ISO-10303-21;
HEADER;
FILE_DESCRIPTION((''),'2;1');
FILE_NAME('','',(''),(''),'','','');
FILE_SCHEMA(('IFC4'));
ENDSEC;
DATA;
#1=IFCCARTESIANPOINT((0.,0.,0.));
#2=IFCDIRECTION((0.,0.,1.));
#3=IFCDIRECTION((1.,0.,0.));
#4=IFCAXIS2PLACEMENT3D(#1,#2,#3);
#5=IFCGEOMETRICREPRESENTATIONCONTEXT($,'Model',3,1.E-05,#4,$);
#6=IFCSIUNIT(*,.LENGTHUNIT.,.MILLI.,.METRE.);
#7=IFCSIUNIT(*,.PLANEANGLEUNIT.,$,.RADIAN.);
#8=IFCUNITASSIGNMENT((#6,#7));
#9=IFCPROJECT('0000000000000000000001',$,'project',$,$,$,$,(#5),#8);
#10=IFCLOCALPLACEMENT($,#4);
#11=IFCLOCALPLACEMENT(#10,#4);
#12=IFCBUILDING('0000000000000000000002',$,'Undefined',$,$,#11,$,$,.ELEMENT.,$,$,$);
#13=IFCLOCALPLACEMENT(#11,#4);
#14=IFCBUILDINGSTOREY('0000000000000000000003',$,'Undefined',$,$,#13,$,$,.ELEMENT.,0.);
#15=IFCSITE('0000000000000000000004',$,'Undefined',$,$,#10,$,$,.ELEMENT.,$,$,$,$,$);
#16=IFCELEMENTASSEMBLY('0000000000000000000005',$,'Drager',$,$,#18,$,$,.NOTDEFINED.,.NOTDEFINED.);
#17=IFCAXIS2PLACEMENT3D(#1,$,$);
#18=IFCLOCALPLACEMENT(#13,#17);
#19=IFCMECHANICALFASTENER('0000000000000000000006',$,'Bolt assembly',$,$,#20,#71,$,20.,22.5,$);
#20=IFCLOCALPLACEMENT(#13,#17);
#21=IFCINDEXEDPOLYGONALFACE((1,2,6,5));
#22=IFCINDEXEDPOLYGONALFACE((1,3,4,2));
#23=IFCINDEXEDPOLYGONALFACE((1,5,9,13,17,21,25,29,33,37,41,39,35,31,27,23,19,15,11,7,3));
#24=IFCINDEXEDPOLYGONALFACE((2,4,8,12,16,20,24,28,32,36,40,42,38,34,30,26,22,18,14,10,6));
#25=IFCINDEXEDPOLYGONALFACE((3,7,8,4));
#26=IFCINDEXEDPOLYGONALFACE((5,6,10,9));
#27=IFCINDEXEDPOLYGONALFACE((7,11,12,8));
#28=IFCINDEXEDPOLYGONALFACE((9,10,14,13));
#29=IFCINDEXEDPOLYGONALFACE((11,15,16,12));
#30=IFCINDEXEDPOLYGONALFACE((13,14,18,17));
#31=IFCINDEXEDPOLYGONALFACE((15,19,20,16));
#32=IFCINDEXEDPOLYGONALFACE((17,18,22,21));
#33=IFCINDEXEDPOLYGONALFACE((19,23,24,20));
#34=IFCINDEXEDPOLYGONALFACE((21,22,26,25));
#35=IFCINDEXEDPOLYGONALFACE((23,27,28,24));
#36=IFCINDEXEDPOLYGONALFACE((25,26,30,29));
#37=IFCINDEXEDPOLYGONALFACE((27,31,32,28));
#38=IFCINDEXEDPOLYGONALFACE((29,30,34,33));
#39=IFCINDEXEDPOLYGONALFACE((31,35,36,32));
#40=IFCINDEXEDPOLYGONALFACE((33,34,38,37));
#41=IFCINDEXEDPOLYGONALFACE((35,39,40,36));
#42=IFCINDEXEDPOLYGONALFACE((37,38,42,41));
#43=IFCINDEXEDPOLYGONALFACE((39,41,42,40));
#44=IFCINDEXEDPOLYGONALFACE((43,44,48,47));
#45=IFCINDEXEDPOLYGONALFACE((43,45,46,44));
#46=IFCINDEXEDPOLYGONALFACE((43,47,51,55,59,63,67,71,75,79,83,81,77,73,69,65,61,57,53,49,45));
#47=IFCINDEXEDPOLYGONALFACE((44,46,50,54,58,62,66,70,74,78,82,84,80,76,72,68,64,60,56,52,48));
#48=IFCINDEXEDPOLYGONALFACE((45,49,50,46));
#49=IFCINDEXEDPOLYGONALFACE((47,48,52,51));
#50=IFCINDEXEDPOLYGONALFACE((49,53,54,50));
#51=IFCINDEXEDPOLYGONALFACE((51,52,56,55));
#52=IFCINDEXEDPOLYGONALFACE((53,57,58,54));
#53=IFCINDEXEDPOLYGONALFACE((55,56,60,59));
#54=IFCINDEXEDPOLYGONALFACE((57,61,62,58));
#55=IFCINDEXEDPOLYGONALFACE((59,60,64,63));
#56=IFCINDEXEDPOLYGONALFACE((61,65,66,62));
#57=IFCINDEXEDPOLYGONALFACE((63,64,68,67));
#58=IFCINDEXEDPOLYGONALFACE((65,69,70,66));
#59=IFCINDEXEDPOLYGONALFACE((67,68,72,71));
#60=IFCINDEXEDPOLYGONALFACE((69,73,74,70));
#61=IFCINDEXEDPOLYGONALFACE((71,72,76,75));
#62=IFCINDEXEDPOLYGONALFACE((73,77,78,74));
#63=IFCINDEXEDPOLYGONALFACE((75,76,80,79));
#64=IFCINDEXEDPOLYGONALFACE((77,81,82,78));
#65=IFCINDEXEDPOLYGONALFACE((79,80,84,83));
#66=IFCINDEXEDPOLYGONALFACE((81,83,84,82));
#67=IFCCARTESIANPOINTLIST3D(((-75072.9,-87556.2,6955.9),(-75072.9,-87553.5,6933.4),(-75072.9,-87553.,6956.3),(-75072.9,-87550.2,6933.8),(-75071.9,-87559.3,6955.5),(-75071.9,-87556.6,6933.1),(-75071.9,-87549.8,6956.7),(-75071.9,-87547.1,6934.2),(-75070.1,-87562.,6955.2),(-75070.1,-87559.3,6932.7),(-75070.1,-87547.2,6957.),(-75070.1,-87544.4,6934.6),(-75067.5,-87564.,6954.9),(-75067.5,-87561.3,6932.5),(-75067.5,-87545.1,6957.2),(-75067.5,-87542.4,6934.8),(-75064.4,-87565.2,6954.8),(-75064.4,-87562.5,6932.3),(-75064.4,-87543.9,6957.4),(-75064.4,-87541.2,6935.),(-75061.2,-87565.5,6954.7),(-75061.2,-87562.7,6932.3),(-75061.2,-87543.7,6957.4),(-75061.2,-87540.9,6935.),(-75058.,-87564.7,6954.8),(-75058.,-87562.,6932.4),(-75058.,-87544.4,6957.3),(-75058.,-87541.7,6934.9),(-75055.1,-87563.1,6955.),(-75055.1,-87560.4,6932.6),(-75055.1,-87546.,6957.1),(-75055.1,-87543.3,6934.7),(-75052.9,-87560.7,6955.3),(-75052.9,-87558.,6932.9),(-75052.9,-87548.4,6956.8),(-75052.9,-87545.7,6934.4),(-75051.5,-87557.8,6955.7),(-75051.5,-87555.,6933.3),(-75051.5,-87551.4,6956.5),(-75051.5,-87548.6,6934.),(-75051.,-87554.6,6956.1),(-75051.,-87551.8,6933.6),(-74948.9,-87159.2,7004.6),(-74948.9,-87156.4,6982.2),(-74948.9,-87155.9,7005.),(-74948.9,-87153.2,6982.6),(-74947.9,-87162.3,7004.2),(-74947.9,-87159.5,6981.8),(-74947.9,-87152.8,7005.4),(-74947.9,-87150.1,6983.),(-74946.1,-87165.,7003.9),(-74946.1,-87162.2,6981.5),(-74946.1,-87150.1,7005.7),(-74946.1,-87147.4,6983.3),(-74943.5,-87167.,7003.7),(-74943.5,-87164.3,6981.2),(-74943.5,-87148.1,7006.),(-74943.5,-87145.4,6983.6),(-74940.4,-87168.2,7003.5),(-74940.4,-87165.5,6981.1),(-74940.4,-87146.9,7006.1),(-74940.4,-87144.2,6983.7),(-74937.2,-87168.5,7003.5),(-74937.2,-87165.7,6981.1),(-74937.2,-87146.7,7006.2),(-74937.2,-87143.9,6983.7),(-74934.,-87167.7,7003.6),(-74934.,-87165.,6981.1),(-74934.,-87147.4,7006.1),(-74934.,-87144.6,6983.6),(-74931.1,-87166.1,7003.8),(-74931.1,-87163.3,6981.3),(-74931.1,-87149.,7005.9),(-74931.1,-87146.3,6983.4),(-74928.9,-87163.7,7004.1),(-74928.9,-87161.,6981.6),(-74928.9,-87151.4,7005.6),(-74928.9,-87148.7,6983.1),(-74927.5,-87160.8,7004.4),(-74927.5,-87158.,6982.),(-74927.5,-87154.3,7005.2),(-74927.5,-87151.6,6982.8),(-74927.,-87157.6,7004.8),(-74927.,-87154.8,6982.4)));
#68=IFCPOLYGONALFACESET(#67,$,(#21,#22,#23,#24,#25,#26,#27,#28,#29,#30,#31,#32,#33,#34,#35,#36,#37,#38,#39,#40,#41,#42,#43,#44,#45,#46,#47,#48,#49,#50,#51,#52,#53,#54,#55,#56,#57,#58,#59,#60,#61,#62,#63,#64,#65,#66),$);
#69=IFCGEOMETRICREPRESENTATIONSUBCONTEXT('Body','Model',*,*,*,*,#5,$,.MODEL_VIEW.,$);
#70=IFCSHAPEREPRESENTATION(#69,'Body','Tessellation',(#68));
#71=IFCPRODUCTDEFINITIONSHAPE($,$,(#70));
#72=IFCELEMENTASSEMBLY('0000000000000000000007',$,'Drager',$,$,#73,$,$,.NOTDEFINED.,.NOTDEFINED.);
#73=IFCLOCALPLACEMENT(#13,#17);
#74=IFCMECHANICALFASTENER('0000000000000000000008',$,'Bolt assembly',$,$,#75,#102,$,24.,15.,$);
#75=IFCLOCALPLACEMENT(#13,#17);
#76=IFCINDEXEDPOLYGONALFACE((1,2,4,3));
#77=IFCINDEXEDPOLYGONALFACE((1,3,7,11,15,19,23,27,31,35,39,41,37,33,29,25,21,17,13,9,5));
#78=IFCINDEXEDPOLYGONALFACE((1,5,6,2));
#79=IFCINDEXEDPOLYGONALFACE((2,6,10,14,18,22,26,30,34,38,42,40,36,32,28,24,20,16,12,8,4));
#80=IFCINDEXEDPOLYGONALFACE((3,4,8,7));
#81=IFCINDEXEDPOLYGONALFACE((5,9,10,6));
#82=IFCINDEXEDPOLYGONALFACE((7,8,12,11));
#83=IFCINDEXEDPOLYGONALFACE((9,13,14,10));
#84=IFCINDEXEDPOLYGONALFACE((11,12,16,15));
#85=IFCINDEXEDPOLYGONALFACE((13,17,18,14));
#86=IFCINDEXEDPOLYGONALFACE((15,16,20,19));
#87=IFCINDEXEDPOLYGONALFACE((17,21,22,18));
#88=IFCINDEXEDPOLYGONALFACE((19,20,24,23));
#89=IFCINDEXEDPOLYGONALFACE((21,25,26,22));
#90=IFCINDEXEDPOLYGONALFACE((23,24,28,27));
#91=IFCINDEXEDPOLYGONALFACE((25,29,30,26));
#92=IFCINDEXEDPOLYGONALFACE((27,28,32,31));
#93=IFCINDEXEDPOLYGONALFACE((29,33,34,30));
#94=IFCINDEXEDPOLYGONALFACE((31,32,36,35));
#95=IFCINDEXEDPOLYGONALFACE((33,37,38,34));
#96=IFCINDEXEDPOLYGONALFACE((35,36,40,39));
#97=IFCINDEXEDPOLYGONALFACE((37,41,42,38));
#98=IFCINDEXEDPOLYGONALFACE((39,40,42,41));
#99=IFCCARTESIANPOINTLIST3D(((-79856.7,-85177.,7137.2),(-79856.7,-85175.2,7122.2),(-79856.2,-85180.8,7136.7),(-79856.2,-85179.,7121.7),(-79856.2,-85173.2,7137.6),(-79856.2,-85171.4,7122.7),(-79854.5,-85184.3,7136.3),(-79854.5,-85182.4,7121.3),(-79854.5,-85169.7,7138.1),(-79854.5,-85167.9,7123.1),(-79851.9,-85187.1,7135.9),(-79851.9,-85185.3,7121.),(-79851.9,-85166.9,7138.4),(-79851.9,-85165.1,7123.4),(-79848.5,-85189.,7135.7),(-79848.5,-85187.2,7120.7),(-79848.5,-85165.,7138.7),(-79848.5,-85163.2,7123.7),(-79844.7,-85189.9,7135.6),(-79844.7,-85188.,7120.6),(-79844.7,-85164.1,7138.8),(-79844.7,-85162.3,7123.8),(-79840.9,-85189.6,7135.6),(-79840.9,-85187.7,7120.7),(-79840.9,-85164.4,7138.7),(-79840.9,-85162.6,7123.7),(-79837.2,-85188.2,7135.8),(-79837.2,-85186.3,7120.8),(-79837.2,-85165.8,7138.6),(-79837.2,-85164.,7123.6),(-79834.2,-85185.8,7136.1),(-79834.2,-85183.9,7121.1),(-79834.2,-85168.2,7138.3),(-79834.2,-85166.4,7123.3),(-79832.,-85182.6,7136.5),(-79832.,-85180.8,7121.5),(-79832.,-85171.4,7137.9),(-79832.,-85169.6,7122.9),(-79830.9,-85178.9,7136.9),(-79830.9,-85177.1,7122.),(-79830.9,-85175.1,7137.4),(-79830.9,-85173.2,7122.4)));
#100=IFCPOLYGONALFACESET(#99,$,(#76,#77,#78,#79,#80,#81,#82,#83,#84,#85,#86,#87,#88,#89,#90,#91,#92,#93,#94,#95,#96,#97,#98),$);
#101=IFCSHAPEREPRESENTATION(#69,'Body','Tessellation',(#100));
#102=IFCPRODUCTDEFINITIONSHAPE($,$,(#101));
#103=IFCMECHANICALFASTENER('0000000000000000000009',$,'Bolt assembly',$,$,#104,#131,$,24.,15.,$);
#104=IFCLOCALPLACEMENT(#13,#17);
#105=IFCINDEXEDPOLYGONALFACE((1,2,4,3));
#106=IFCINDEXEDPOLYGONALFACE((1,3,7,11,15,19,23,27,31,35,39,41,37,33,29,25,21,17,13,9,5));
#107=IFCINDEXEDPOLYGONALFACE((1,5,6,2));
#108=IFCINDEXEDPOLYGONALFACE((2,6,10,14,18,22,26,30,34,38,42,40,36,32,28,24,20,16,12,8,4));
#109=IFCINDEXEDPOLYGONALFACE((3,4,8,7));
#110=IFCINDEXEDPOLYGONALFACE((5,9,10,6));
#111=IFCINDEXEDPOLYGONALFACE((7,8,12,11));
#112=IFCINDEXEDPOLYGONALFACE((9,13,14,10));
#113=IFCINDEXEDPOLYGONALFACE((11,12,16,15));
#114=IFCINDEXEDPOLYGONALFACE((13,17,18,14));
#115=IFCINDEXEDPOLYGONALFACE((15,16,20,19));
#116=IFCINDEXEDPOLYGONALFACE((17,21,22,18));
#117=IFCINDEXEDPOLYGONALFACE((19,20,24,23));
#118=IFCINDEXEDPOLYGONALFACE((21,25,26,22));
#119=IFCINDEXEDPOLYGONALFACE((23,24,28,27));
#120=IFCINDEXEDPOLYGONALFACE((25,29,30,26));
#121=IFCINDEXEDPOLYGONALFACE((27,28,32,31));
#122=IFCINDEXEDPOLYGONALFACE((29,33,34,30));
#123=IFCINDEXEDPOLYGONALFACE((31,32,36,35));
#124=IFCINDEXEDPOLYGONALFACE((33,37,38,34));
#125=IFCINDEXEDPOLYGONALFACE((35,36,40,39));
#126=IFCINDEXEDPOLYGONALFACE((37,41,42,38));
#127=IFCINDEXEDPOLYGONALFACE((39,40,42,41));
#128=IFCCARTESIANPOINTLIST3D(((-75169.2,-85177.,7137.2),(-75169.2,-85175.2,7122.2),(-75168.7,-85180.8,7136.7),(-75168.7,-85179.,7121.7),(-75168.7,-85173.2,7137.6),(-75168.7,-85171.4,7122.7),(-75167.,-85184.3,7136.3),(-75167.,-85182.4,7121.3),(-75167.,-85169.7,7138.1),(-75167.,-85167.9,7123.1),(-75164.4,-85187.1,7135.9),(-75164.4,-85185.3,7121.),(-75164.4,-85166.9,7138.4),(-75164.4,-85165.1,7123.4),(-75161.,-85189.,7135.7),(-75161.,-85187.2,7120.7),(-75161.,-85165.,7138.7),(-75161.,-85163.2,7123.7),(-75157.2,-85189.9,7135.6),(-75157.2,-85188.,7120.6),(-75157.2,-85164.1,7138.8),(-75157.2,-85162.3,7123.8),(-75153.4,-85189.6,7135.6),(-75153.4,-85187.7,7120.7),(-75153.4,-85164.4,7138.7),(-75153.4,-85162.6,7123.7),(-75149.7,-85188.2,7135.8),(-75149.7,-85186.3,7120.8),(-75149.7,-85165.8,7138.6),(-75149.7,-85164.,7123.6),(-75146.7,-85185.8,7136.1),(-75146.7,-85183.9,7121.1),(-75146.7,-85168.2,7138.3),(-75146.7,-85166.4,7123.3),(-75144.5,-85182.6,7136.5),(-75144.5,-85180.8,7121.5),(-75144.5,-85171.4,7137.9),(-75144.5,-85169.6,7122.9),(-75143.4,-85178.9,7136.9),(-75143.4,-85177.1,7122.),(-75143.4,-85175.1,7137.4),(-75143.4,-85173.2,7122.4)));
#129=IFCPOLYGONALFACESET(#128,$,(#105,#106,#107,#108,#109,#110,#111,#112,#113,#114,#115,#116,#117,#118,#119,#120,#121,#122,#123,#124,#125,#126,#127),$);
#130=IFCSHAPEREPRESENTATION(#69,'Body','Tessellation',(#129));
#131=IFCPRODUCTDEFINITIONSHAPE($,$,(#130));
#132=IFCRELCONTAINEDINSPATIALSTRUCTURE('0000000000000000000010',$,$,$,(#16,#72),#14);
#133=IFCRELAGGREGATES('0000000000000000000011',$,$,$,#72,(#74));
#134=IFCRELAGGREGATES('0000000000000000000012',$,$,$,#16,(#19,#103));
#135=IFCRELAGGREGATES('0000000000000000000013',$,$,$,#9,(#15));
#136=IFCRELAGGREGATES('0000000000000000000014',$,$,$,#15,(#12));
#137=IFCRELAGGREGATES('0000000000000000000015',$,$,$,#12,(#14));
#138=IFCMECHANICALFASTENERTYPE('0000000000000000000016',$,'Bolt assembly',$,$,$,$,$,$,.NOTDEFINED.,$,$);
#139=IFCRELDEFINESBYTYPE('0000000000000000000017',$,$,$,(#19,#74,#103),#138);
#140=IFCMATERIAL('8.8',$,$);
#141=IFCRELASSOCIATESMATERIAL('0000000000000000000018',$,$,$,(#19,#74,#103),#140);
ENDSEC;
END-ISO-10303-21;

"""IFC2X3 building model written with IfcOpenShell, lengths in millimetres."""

from ifc_helpers import new_model, si_unit, frame, origin_with_axes, origin_2d_with_axis, place, context, subcontext, project, spatial, circle, extrude, source, transform, mapped, material, type_object, element, aggregate, save


model = new_model("IFC2X3")

# Units and contexts
model_context = context("Model", 3, precision=1e-05, world=origin_with_axes())
body_context = subcontext(model_context, "Body", "Model", "MODEL_VIEW")
ifc_project = project(units=[si_unit("LENGTHUNIT", "METRE", prefix="MILLI"), si_unit("PLANEANGLEUNIT", "RADIAN")], contexts=[model_context])

# Site, building, storey
site_placement = place(None, origin_with_axes())
site = spatial("IfcSite", under=ifc_project, at=site_placement, Name="Undefined", CompositionType="ELEMENT")
building_placement = place(site_placement, origin_with_axes())
building = spatial("IfcBuilding", under=site, at=building_placement, Name="Undefined", CompositionType="ELEMENT")
storey_placement = place(building_placement, origin_with_axes())
storey = spatial("IfcBuildingStorey", under=building, at=storey_placement, Name="Undefined", CompositionType="ELEMENT", Elevation=0.0)

# Element assembly
assembly_1_placement = place(storey_placement, origin_with_axes())
assembly_1 = element("IfcElementAssembly", 1, at=assembly_1_placement, inside=storey, Name="Drager", AssemblyPlace="NOTDEFINED", PredefinedType="NOTDEFINED")

# Mechanical fastener
ifc_material_1 = material(Name="8.8")
mechanical_fastener_type = type_object("IfcMechanicalFastenerType", Name="Bolt assembly")
shared_shape_1 = source(origin_with_axes(), body_context, "Body", "SweptSolid", [
    extrude(circle(Radius=11.0, at=origin_2d_with_axis()), frame((0.0, 0.0, 0.0), z_axis=(0.0, 1.0, 0.0), x_axis=(1.0, 0.0, 0.0)), (0.0, 0.0, 1.0), 22.6),
])
mechanical_fastener_1_placement = place(assembly_1_placement, frame((-75150.0, -87356.1, 6980.5), z_axis=(0.0, 0.992546, 0.121869), x_axis=(1.0, 0.0, 0.0)))
mechanical_fastener_1 = element("IfcMechanicalFastener", 2, at=mechanical_fastener_1_placement, type_object=mechanical_fastener_type, material=ifc_material_1, Name="Bolt assembly", NominalDiameter=20.0, NominalLength=22.5, context=body_context, shape_type="MappedRepresentation", body=[
    mapped(shared_shape_1, transform((88.0, 0.0, -200.0))),
    mapped(shared_shape_1, transform((212.0, 0.0, 200.0))),
])

# Element assembly, mechanical fastener
assembly_2_placement = place(storey_placement, origin_with_axes())
assembly_2 = element("IfcElementAssembly", 3, at=assembly_2_placement, inside=storey, Name="Drager", AssemblyPlace="NOTDEFINED", PredefinedType="NOTDEFINED")
shared_shape_2 = source(origin_with_axes(), body_context, "Body", "SweptSolid", [
    extrude(circle(Radius=13.0, at=origin_2d_with_axis()), frame((0.0, -7.5, 0.0), z_axis=(0.0, 1.0, 0.0), x_axis=(1.0, 0.0, 0.0)), (0.0, 0.0, 1.0), 15.1),
])
mechanical_fastener_2_placement = place(assembly_2_placement, frame((-79843.7, -85176.1, 7129.7), z_axis=(0.0, -0.992546, -0.121869), x_axis=(-1.0, 0.0, 0.0)))
mechanical_fastener_2 = element("IfcMechanicalFastener", 4, at=mechanical_fastener_2_placement, type_object=mechanical_fastener_type, material=ifc_material_1, Name="Bolt assembly", NominalDiameter=24.0, NominalLength=15.0, context=body_context, shape_type="MappedRepresentation", body=[
    mapped(shared_shape_2, transform((0.0, 0.0, 0.0))),
])
aggregate(assembly_2, [mechanical_fastener_2])

# Mechanical fastener
mechanical_fastener_3_placement = place(assembly_1_placement, frame((-75156.2, -85176.1, 7129.7), z_axis=(0.0, -0.992546, -0.121869), x_axis=(-1.0, 0.0, 0.0)))
mechanical_fastener_3 = element("IfcMechanicalFastener", 5, at=mechanical_fastener_3_placement, type_object=mechanical_fastener_type, material=ifc_material_1, Name="Bolt assembly", NominalDiameter=24.0, NominalLength=15.0, context=body_context, shape_type="MappedRepresentation", body=[
    mapped(shared_shape_2, transform((0.0, 0.0, 0.0))),
])
aggregate(assembly_1, [mechanical_fastener_1, mechanical_fastener_3])

save(model, "model.ifc")
